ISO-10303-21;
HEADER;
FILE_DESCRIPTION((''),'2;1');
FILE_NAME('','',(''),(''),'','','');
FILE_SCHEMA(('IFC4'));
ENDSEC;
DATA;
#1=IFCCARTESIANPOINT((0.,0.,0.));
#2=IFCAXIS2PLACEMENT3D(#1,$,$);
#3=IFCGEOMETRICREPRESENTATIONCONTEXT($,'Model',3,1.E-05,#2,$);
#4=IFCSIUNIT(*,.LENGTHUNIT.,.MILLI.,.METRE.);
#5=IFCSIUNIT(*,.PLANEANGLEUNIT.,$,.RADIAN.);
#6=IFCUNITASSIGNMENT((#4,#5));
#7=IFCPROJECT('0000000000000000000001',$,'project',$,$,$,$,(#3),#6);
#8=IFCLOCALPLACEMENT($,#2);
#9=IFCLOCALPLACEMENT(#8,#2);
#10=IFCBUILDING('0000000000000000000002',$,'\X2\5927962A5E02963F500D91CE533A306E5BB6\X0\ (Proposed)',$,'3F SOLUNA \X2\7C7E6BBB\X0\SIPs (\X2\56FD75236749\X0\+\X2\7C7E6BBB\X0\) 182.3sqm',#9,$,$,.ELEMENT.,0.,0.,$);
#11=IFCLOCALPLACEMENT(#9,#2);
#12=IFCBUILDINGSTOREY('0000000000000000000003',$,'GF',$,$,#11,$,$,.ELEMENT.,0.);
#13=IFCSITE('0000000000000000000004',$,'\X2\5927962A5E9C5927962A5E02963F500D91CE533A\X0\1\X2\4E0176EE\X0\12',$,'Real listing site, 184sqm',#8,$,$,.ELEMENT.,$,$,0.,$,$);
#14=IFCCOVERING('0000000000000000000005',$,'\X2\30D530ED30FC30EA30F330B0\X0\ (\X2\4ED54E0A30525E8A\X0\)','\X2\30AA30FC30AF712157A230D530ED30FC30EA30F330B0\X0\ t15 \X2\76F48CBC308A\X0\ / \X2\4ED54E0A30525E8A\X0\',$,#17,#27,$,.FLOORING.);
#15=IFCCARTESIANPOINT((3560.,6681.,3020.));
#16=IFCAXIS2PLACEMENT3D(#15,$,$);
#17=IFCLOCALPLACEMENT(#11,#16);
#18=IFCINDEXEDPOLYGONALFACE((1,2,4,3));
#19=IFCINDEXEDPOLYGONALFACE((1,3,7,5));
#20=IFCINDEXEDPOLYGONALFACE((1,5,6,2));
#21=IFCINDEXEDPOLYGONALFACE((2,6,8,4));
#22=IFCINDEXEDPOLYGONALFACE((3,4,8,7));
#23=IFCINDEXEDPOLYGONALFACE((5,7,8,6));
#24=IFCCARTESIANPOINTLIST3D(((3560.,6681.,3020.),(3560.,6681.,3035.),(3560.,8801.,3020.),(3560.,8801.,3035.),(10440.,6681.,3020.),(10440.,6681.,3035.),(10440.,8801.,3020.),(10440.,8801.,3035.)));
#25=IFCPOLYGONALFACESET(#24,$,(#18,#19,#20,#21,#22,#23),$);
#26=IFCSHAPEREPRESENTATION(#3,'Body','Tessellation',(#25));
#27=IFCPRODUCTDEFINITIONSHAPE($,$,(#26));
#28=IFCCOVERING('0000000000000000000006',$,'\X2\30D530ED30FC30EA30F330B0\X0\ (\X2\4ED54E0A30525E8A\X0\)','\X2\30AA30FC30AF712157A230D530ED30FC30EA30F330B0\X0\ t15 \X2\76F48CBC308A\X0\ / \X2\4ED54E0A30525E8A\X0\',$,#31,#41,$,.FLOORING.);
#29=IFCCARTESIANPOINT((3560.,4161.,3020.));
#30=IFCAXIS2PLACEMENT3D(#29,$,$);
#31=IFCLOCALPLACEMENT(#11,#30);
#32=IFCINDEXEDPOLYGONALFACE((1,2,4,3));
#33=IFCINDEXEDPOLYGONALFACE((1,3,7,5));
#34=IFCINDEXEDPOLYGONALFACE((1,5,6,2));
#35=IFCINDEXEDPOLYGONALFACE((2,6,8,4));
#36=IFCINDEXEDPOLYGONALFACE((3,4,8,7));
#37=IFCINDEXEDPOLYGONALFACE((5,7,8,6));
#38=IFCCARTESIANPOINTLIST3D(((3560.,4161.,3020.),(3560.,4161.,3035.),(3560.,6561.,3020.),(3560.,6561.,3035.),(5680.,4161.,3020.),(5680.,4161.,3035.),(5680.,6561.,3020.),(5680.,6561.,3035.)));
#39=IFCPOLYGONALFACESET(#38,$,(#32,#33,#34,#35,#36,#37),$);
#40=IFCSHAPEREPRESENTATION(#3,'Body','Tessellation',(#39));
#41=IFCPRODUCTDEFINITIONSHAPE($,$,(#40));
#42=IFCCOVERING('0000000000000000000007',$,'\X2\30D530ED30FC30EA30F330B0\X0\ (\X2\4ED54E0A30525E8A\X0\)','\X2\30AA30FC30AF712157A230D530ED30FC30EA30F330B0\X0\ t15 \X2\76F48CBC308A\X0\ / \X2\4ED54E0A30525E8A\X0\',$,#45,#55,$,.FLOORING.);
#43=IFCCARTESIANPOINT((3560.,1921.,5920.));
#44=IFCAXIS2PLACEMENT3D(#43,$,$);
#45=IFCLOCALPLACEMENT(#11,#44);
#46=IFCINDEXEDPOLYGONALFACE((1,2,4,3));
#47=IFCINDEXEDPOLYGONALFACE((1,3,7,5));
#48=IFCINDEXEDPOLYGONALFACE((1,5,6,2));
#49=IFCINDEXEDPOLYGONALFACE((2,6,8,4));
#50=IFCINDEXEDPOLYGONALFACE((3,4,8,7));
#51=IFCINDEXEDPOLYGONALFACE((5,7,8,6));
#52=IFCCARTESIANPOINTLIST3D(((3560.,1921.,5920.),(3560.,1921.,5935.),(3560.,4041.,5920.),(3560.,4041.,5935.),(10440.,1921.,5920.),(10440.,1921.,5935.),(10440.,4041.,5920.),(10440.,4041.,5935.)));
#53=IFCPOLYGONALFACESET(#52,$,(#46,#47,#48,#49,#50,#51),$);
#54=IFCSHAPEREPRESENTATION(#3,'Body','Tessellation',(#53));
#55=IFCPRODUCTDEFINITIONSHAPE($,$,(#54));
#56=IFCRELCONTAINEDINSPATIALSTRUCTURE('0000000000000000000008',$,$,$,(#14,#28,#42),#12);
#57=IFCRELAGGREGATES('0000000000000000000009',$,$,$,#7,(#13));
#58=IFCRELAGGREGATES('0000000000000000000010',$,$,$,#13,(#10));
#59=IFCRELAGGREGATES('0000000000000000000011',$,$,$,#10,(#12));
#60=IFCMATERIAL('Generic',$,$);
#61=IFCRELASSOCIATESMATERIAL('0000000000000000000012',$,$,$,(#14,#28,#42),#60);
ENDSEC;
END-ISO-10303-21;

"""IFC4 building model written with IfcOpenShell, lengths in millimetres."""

from ifc_helpers import new_model, si_unit, frame, frame_2d, origin, place, context, project, spatial, rectangle, extrude, material, element, save


model = new_model("IFC4")

# Units and contexts
model_context = context("Model", 3, precision=1e-05, world=origin())
ifc_project = project(units=[si_unit("LENGTHUNIT", "METRE", prefix="MILLI"), si_unit("PLANEANGLEUNIT", "RADIAN")], contexts=[model_context])

# Site, building, storey
site_placement = place(None, origin())
site = spatial("IfcSite", under=ifc_project, at=site_placement, Name="大阪府大阪市阿倍野区1丁目12", ObjectType="Real listing site, 184sqm", CompositionType="ELEMENT", RefElevation=0.0)
building_placement = place(site_placement, origin())
building = spatial("IfcBuilding", under=site, at=building_placement, Name="大阪市阿倍野区の家 (Proposed)", ObjectType="3F SOLUNA 籾殻SIPs (国産杉+籾殻) 182.3sqm", CompositionType="ELEMENT", ElevationOfRefHeight=0.0, ElevationOfTerrain=0.0)
storey_placement = place(building_placement, origin())
storey = spatial("IfcBuildingStorey", under=building, at=storey_placement, Name="GF", CompositionType="ELEMENT", Elevation=0.0)

# Shared definitions
ifc_material_1 = material(Name="Generic")

# Coverings
covering_1_placement = place(storey_placement, frame((3560.0, 6681.0, 3020.0)))
element("IfcCovering", 1, at=covering_1_placement, inside=storey, material=ifc_material_1, Name="フローリング (仕上げ床)", Description="オーク無垢フローリング t15 直貼り / 仕上げ床", PredefinedType="FLOORING", context=model_context, shape_type="SweptSolid", body=[
    extrude(rectangle(XDim=6880.0, YDim=2120.0, at=frame_2d((3440.0, 1060.0))), frame((3560.0, 6681.0, 3020.0)), (0.0, 0.0, 1.0), 15.0),
])
covering_2_placement = place(storey_placement, frame((3560.0, 4161.0, 3020.0)))
element("IfcCovering", 2, at=covering_2_placement, inside=storey, material=ifc_material_1, Name="フローリング (仕上げ床)", Description="オーク無垢フローリング t15 直貼り / 仕上げ床", PredefinedType="FLOORING", context=model_context, shape_type="SweptSolid", body=[
    extrude(rectangle(XDim=2120.0, YDim=2400.0, at=frame_2d((1060.0, 1200.0))), frame((3560.0, 4161.0, 3020.0)), (0.0, 0.0, 1.0), 15.0),
])
covering_3_placement = place(storey_placement, frame((3560.0, 1921.0, 5920.0)))
element("IfcCovering", 3, at=covering_3_placement, inside=storey, material=ifc_material_1, Name="フローリング (仕上げ床)", Description="オーク無垢フローリング t15 直貼り / 仕上げ床", PredefinedType="FLOORING", context=model_context, shape_type="SweptSolid", body=[
    extrude(rectangle(XDim=6880.0, YDim=2120.0, at=frame_2d((3440.0, 1060.0))), frame((3560.0, 1921.0, 5920.0)), (0.0, 0.0, 1.0), 15.0),
])

save(model, "model.ifc")
